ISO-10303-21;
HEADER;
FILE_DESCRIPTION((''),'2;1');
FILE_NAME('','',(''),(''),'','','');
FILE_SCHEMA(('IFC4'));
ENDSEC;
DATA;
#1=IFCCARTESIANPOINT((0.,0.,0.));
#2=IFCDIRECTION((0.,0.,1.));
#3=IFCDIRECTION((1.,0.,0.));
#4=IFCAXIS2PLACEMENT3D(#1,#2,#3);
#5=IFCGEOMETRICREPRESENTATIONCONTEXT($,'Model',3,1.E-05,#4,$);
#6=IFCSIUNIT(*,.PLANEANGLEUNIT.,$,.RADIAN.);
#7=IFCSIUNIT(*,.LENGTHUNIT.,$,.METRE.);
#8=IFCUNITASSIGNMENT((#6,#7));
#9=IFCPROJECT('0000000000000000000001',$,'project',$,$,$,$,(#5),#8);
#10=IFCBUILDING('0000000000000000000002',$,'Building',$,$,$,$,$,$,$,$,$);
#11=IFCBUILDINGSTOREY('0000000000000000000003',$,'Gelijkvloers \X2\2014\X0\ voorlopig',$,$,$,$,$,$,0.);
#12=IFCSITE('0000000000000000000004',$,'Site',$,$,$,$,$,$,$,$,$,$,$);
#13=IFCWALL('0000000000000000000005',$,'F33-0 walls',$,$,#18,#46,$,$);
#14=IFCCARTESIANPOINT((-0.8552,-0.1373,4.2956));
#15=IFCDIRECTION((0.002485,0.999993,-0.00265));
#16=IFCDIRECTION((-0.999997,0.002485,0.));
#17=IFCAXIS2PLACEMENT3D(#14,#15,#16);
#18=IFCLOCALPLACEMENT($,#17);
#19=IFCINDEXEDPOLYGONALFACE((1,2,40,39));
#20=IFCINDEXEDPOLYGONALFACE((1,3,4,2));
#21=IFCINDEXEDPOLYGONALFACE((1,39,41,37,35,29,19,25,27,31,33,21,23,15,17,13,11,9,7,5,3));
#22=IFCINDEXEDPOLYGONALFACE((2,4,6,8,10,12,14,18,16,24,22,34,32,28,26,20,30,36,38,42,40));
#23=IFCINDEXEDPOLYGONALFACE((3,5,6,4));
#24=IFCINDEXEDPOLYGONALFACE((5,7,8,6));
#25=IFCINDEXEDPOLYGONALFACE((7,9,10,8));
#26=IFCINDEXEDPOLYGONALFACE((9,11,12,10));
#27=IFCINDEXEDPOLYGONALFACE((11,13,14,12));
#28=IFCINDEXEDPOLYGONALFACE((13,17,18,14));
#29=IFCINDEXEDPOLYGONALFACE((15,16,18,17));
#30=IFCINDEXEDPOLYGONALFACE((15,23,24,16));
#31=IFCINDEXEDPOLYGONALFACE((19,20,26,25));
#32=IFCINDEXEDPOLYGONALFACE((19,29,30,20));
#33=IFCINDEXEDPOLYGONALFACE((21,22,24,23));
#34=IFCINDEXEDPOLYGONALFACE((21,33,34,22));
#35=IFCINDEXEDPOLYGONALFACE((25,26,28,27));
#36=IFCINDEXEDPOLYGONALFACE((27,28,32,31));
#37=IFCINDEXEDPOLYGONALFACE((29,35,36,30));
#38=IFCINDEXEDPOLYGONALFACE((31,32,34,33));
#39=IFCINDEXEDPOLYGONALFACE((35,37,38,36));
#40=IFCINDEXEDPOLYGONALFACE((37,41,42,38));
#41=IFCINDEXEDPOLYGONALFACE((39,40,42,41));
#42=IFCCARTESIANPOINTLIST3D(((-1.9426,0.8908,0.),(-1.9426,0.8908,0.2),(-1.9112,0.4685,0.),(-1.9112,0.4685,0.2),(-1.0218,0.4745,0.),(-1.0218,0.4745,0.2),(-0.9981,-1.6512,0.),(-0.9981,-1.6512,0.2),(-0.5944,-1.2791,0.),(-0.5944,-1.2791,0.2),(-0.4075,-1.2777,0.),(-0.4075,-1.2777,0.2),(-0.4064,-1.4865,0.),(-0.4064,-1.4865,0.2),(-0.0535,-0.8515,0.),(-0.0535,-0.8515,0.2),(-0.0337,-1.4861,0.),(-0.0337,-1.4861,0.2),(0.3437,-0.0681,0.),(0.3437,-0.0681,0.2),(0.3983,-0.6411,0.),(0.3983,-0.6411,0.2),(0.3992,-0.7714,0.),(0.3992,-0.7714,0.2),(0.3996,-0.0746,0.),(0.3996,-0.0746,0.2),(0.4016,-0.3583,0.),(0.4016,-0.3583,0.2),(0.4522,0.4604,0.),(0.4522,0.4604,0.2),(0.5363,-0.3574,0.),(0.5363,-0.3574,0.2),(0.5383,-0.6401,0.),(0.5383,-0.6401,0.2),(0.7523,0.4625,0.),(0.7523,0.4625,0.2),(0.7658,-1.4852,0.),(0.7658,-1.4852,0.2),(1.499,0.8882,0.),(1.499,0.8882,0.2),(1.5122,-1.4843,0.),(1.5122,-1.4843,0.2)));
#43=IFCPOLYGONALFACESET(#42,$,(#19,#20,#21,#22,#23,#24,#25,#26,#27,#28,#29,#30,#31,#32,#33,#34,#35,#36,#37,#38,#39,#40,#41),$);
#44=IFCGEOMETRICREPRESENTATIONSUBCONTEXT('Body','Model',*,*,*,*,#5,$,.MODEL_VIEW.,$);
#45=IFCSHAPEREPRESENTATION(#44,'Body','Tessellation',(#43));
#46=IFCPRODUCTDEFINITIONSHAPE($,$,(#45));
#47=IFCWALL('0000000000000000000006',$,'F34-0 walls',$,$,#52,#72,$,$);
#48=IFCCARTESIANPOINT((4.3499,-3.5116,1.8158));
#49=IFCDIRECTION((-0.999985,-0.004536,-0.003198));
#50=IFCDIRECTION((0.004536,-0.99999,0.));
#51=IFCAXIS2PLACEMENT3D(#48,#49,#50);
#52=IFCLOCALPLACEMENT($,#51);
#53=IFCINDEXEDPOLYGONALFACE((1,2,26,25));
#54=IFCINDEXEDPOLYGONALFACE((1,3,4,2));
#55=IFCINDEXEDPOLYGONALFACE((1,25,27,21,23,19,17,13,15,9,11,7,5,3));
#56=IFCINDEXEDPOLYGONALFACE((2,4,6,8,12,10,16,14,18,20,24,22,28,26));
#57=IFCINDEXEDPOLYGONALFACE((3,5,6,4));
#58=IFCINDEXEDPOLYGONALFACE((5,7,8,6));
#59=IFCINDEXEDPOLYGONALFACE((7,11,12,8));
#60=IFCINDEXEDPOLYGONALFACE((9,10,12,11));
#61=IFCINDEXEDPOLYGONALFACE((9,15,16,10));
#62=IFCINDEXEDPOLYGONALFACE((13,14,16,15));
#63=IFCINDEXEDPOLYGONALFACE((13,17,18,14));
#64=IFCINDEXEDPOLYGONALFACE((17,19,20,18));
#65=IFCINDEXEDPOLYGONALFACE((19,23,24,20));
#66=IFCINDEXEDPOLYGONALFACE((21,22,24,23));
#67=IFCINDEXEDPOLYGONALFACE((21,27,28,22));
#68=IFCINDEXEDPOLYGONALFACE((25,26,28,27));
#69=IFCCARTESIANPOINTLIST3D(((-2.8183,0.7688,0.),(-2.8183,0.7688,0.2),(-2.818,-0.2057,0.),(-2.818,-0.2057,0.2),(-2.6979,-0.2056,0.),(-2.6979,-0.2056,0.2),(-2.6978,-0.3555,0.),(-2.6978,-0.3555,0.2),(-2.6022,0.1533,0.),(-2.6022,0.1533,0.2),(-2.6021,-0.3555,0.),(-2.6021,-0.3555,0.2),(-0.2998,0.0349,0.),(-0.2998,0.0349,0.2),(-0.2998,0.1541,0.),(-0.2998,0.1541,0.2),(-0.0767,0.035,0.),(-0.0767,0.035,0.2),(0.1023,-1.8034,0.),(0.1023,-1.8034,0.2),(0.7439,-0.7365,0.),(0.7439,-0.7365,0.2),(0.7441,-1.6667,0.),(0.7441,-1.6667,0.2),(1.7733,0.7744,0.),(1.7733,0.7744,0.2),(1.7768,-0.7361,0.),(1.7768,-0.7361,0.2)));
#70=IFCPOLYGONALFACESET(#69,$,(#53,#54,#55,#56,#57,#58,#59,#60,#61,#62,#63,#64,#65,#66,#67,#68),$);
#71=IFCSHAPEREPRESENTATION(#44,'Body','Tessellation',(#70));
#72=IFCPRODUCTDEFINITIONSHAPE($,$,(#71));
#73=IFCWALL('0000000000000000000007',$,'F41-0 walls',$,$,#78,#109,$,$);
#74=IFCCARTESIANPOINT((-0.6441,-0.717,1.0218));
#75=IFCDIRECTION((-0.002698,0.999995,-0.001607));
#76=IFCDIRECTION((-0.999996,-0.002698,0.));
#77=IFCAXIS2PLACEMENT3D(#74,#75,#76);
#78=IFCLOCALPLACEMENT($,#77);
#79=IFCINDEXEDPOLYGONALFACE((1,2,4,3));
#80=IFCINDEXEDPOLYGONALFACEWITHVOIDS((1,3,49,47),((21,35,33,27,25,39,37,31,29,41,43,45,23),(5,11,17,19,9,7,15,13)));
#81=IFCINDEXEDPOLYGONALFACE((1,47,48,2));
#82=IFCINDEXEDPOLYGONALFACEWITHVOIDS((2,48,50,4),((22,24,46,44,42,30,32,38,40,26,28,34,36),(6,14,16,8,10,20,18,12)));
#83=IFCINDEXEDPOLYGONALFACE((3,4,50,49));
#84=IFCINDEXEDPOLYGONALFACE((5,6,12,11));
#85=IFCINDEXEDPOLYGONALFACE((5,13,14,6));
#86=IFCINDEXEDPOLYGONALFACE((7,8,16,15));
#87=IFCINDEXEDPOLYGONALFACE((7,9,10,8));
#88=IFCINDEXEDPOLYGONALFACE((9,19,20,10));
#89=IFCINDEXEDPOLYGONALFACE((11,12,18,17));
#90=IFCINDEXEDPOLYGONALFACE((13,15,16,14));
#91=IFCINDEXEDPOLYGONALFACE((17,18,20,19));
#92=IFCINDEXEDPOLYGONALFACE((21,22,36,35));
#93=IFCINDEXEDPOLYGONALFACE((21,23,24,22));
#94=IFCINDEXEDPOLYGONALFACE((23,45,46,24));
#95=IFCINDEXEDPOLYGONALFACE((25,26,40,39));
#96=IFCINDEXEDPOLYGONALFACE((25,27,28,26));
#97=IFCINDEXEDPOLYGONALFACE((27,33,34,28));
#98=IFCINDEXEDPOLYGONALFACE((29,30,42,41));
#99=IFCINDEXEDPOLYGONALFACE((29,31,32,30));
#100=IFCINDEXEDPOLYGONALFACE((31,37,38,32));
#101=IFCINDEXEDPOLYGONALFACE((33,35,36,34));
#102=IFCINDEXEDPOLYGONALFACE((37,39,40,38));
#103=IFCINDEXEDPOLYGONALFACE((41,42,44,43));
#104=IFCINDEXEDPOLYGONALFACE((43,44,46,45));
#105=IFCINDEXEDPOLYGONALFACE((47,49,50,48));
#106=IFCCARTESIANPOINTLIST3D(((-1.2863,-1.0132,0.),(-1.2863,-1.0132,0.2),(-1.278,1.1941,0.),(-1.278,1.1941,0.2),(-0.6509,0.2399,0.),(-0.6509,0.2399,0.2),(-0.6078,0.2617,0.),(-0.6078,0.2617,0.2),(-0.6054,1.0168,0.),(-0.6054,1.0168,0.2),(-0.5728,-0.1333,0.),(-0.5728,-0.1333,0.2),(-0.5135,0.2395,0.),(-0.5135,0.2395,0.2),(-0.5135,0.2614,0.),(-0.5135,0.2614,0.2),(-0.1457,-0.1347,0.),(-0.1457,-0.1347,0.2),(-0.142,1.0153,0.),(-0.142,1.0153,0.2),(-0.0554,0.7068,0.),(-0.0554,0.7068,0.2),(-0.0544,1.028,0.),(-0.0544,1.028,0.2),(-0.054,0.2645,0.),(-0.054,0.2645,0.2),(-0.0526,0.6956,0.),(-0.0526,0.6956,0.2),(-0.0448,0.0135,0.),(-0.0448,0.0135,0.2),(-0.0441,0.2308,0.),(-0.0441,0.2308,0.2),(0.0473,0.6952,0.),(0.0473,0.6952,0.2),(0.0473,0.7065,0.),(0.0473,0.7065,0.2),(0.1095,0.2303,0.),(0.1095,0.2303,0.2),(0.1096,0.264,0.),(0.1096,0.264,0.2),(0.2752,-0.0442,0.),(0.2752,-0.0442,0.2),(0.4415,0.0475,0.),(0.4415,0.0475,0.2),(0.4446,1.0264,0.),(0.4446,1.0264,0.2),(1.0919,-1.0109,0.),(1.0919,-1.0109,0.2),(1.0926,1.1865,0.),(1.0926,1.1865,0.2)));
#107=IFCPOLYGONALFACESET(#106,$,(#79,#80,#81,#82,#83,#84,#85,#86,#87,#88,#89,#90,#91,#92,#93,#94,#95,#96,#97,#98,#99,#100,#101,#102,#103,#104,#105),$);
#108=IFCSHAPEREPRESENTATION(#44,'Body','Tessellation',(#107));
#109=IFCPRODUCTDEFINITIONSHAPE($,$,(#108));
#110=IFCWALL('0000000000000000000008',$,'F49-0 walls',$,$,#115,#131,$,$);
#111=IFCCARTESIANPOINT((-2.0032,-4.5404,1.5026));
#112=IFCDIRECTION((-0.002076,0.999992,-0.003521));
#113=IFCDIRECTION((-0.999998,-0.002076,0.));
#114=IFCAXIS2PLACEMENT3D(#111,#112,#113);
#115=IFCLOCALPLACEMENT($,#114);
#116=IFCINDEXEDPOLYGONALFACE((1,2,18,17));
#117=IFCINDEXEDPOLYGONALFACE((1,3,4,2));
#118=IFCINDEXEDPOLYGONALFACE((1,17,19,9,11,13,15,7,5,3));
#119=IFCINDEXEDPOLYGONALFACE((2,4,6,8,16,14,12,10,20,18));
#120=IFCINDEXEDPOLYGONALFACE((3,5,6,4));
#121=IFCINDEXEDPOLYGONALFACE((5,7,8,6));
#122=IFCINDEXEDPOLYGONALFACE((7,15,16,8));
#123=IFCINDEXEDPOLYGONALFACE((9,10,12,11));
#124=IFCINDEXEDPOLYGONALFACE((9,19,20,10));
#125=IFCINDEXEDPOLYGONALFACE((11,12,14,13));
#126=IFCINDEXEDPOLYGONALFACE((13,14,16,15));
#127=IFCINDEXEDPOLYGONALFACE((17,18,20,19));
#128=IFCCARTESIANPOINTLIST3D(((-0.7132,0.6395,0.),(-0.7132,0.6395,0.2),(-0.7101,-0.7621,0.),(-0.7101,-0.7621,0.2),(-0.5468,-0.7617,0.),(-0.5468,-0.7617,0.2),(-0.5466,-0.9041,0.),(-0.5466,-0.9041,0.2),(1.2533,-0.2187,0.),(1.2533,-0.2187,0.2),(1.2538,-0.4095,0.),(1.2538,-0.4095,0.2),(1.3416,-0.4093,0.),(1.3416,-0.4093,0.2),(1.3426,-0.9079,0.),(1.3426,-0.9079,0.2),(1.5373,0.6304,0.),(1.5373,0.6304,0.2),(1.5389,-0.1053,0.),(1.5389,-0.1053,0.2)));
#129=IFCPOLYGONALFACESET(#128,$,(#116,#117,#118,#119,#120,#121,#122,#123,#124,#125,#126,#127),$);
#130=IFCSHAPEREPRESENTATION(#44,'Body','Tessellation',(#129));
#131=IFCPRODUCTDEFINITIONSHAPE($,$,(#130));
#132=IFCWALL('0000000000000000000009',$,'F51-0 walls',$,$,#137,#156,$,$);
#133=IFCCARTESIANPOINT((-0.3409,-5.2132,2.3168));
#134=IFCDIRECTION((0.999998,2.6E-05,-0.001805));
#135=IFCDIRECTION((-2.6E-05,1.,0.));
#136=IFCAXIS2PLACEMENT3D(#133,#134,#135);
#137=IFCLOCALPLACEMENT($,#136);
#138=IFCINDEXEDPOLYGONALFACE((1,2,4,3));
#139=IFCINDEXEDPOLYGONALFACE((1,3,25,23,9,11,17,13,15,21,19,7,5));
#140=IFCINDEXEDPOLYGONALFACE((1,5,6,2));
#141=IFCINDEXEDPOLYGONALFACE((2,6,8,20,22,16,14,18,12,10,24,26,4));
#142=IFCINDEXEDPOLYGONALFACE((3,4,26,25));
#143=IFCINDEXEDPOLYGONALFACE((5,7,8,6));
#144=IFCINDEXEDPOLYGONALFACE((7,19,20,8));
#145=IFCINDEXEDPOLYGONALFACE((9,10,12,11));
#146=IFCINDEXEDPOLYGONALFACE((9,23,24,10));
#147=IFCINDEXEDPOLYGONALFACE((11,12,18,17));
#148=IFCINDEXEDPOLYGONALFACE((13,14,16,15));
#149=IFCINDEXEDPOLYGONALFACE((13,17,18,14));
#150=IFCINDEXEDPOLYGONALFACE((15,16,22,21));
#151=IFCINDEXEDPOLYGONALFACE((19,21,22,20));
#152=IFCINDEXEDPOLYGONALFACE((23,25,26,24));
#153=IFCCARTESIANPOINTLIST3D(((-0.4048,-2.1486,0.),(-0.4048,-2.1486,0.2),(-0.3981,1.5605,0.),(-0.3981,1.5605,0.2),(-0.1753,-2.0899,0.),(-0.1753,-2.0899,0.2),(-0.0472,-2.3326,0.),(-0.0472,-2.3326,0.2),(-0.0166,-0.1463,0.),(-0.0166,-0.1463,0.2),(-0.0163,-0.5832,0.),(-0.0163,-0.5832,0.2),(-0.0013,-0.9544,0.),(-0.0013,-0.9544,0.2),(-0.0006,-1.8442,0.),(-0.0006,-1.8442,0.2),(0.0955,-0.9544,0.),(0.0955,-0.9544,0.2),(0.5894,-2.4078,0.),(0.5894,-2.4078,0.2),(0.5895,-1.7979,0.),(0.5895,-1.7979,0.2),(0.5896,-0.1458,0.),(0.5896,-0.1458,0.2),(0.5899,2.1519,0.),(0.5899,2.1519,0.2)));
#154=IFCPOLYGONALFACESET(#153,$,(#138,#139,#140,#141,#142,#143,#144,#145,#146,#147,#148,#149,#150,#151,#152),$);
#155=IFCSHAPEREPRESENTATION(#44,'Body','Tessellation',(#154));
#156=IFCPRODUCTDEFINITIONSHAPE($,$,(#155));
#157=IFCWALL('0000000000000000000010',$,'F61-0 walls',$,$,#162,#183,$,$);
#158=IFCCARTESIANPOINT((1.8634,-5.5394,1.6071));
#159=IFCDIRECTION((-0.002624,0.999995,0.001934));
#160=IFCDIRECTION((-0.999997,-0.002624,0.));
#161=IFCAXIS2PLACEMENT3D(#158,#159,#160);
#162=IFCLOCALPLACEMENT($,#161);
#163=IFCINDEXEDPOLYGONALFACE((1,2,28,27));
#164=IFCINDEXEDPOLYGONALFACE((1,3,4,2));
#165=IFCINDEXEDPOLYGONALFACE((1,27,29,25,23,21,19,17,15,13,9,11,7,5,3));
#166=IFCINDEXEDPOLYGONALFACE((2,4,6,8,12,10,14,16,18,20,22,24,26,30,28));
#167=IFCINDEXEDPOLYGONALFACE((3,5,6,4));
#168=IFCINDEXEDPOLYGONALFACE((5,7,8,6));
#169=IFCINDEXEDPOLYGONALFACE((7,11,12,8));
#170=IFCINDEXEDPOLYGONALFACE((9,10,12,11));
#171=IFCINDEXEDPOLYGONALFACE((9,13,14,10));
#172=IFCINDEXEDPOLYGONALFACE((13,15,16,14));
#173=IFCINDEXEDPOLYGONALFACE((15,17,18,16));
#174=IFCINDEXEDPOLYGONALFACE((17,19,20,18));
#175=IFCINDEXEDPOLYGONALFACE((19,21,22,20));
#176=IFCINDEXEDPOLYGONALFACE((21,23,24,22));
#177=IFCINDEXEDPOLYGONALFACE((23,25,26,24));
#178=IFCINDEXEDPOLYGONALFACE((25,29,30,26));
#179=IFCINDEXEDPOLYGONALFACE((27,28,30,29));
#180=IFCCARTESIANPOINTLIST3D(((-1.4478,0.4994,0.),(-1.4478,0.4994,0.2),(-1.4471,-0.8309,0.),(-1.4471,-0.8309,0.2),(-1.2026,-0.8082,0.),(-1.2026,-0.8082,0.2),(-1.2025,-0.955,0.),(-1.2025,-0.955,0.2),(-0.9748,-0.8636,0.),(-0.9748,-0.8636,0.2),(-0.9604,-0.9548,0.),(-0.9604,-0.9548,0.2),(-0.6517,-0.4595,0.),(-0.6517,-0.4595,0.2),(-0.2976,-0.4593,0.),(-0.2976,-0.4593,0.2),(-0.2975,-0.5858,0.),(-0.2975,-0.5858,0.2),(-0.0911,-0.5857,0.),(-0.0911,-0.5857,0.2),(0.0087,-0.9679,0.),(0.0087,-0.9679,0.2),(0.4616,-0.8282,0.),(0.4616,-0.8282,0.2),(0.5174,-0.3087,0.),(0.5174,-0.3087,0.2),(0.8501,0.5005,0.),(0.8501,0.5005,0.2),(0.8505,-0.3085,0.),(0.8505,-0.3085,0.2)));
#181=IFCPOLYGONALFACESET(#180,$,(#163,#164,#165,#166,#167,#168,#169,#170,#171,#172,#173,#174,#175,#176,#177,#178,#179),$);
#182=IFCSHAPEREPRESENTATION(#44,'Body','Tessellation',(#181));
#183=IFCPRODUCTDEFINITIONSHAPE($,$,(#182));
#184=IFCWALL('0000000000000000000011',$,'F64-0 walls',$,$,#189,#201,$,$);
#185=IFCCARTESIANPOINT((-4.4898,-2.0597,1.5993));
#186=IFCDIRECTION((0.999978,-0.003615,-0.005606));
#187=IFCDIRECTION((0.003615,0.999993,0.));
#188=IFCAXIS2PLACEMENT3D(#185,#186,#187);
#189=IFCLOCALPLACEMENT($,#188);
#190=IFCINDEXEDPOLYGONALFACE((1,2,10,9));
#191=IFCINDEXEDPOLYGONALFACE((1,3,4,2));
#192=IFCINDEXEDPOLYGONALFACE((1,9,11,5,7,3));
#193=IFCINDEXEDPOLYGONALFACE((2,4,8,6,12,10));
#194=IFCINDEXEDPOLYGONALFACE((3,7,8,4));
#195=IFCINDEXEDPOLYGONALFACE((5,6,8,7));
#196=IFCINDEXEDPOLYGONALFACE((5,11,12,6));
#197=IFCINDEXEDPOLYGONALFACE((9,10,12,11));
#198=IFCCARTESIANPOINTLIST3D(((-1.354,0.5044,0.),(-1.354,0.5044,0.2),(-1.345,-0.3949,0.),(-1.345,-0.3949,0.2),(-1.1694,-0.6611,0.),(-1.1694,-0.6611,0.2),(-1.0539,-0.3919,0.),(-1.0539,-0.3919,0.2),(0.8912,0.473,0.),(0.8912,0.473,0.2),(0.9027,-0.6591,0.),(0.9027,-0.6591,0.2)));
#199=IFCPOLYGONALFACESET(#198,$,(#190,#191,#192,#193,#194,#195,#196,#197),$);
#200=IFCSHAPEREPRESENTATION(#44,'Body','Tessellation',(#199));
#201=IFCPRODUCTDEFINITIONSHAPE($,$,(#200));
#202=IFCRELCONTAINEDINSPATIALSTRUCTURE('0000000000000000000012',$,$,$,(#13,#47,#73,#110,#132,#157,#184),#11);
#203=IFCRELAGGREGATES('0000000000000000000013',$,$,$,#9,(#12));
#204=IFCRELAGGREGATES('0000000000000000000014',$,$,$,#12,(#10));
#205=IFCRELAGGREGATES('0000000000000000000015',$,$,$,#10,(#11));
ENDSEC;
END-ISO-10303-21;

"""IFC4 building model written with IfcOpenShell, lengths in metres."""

from ifc_helpers import new_model, si_unit, frame, origin_with_axes, place, context, subcontext, project, spatial, polyline, outline, extrude, element, save


model = new_model("IFC4")

# Units and contexts
model_context = context("Model", 3, precision=1e-05, world=origin_with_axes())
body_context = subcontext(model_context, "Body", "Model", "MODEL_VIEW")
ifc_project = project(units=[si_unit("PLANEANGLEUNIT", "RADIAN"), si_unit("LENGTHUNIT", "METRE")], contexts=[model_context])

# Site, building, storey
site = spatial("IfcSite", under=ifc_project, Name="Site")
building = spatial("IfcBuilding", under=site, Name="Building")
storey = spatial("IfcBuildingStorey", under=building, Name="Gelijkvloers — voorlopig", Elevation=0.0)

# Walls
wall_1_placement = place(None, frame((-0.8552, -0.1373, 4.2956), z_axis=(0.002485, 0.999993, -0.00265), x_axis=(-0.999997, 0.002485, 0.0)))
element("IfcWall", 1, at=wall_1_placement, inside=storey, Name="F33-0 walls", context=body_context, shape_type="SweptSolid", body=[
    extrude(outline(polyline([(-0.9981, -1.6512), (-0.5944, -1.2791), (-0.4075, -1.2777), (-0.4064, -1.4865), (-0.0337, -1.4861), (-0.0535, -0.8515), (0.3992, -0.7714), (0.3983, -0.6411), (0.5383, -0.6401), (0.5363, -0.3574), (0.4016, -0.3583), (0.3996, -0.0746), (0.3437, -0.0681), (0.4522, 0.4604), (0.7523, 0.4625), (0.7658, -1.4852), (1.5122, -1.4843), (1.499, 0.8882), (-1.9426, 0.8908), (-1.9112, 0.4685), (-1.0218, 0.4745), (-0.9981, -1.6512)])), origin_with_axes(), (0.0, 0.0, 1.0), 0.2),
])
wall_2_placement = place(None, frame((4.3499, -3.5116, 1.8158), z_axis=(-0.999985, -0.004536, -0.003198), x_axis=(0.004536, -0.99999, 0.0)))
element("IfcWall", 2, at=wall_2_placement, inside=storey, Name="F34-0 walls", context=body_context, shape_type="SweptSolid", body=[
    extrude(outline(polyline([(0.1023, -1.8034), (0.7441, -1.6667), (0.7439, -0.7365), (1.7768, -0.7361), (1.7733, 0.7744), (-2.8183, 0.7688), (-2.818, -0.2057), (-2.6979, -0.2056), (-2.6978, -0.3555), (-2.6021, -0.3555), (-2.6022, 0.1533), (-0.2998, 0.1541), (-0.2998, 0.0349), (-0.0767, 0.035), (0.1023, -1.8034)])), origin_with_axes(), (0.0, 0.0, 1.0), 0.2),
])

# Wall, openings
wall_3_placement = place(None, frame((-0.6441, -0.717, 1.0218), z_axis=(-0.002698, 0.999995, -0.001607), x_axis=(-0.999996, -0.002698, 0.0)))
wall_3 = element("IfcWall", 3, at=wall_3_placement, inside=storey, Name="F41-0 walls", context=body_context, shape_type="SweptSolid", body=[
    extrude(outline(polyline([(-1.2863, -1.0132), (1.0919, -1.0109), (1.0926, 1.1865), (-1.278, 1.1941), (-1.2863, -1.0132)])), origin_with_axes(), (0.0, 0.0, 1.0), 0.2),
])
opening_1_placement = place(wall_3_placement, frame((0.0, 0.0, -0.05), z_axis=(0.0, 0.0, 1.0), x_axis=(1.0, 0.0, 0.0)))
element("IfcOpeningElement", 4, at=opening_1_placement, cuts=wall_3, PredefinedType="OPENING", context=body_context, shape_type="SweptSolid", body=[
    extrude(outline(polyline([(-0.6509, 0.2399), (-0.5135, 0.2395), (-0.5135, 0.2614), (-0.6078, 0.2617), (-0.6054, 1.0168), (-0.142, 1.0153), (-0.1457, -0.1347), (-0.5728, -0.1333), (-0.6509, 0.2399)])), origin_with_axes(), (0.0, 0.0, 1.0), 0.3),
])
opening_2_placement = place(wall_3_placement, frame((0.0, 0.0, -0.05), z_axis=(0.0, 0.0, 1.0), x_axis=(1.0, 0.0, 0.0)))
element("IfcOpeningElement", 5, at=opening_2_placement, cuts=wall_3, PredefinedType="OPENING", context=body_context, shape_type="SweptSolid", body=[
    extrude(outline(polyline([(-0.0448, 0.0135), (-0.0441, 0.2308), (0.1095, 0.2303), (0.1096, 0.264), (-0.054, 0.2645), (-0.0526, 0.6956), (0.0473, 0.6952), (0.0473, 0.7065), (-0.0554, 0.7068), (-0.0544, 1.028), (0.4446, 1.0264), (0.4415, 0.0475), (0.2752, -0.0442), (-0.0448, 0.0135)])), origin_with_axes(), (0.0, 0.0, 1.0), 0.3),
])

# Walls
wall_4_placement = place(None, frame((-2.0032, -4.5404, 1.5026), z_axis=(-0.002076, 0.999992, -0.003521), x_axis=(-0.999998, -0.002076, 0.0)))
element("IfcWall", 6, at=wall_4_placement, inside=storey, Name="F49-0 walls", context=body_context, shape_type="SweptSolid", body=[
    extrude(outline(polyline([(-0.5466, -0.9041), (1.3426, -0.9079), (1.3416, -0.4093), (1.2538, -0.4095), (1.2533, -0.2187), (1.5389, -0.1053), (1.5373, 0.6304), (-0.7132, 0.6395), (-0.7101, -0.7621), (-0.5468, -0.7617), (-0.5466, -0.9041)])), origin_with_axes(), (0.0, 0.0, 1.0), 0.2),
])
wall_5_placement = place(None, frame((-0.3409, -5.2132, 2.3168), z_axis=(0.999998, 0.000026, -0.001805), x_axis=(-0.000026, 1.0, 0.0)))
element("IfcWall", 7, at=wall_5_placement, inside=storey, Name="F51-0 walls", context=body_context, shape_type="SweptSolid", body=[
    extrude(outline(polyline([(0.5894, -2.4078), (0.5895, -1.7979), (-0.0006, -1.8442), (-0.0013, -0.9544), (0.0955, -0.9544), (-0.0163, -0.5832), (-0.0166, -0.1463), (0.5896, -0.1458), (0.5899, 2.1519), (-0.3981, 1.5605), (-0.4048, -2.1486), (-0.1753, -2.0899), (-0.0472, -2.3326), (0.5894, -2.4078)])), origin_with_axes(), (0.0, 0.0, 1.0), 0.2),
])
wall_6_placement = place(None, frame((1.8634, -5.5394, 1.6071), z_axis=(-0.002624, 0.999995, 0.001934), x_axis=(-0.999997, -0.002624, 0.0)))
element("IfcWall", 8, at=wall_6_placement, inside=storey, Name="F61-0 walls", context=body_context, shape_type="SweptSolid", body=[
    extrude(outline(polyline([(0.0087, -0.9679), (0.4616, -0.8282), (0.5174, -0.3087), (0.8505, -0.3085), (0.8501, 0.5005), (-1.4478, 0.4994), (-1.4471, -0.8309), (-1.2026, -0.8082), (-1.2025, -0.955), (-0.9604, -0.9548), (-0.9748, -0.8636), (-0.6517, -0.4595), (-0.2976, -0.4593), (-0.2975, -0.5858), (-0.0911, -0.5857), (0.0087, -0.9679)])), origin_with_axes(), (0.0, 0.0, 1.0), 0.2),
])
wall_7_placement = place(None, frame((-4.4898, -2.0597, 1.5993), z_axis=(0.999978, -0.003615, -0.005606), x_axis=(0.003615, 0.999993, 0.0)))
element("IfcWall", 9, at=wall_7_placement, inside=storey, Name="F64-0 walls", context=body_context, shape_type="SweptSolid", body=[
    extrude(outline(polyline([(-1.1694, -0.6611), (0.9027, -0.6591), (0.8912, 0.473), (-1.354, 0.5044), (-1.345, -0.3949), (-1.0539, -0.3919), (-1.1694, -0.6611)])), origin_with_axes(), (0.0, 0.0, 1.0), 0.2),
])

save(model, "model.ifc")
